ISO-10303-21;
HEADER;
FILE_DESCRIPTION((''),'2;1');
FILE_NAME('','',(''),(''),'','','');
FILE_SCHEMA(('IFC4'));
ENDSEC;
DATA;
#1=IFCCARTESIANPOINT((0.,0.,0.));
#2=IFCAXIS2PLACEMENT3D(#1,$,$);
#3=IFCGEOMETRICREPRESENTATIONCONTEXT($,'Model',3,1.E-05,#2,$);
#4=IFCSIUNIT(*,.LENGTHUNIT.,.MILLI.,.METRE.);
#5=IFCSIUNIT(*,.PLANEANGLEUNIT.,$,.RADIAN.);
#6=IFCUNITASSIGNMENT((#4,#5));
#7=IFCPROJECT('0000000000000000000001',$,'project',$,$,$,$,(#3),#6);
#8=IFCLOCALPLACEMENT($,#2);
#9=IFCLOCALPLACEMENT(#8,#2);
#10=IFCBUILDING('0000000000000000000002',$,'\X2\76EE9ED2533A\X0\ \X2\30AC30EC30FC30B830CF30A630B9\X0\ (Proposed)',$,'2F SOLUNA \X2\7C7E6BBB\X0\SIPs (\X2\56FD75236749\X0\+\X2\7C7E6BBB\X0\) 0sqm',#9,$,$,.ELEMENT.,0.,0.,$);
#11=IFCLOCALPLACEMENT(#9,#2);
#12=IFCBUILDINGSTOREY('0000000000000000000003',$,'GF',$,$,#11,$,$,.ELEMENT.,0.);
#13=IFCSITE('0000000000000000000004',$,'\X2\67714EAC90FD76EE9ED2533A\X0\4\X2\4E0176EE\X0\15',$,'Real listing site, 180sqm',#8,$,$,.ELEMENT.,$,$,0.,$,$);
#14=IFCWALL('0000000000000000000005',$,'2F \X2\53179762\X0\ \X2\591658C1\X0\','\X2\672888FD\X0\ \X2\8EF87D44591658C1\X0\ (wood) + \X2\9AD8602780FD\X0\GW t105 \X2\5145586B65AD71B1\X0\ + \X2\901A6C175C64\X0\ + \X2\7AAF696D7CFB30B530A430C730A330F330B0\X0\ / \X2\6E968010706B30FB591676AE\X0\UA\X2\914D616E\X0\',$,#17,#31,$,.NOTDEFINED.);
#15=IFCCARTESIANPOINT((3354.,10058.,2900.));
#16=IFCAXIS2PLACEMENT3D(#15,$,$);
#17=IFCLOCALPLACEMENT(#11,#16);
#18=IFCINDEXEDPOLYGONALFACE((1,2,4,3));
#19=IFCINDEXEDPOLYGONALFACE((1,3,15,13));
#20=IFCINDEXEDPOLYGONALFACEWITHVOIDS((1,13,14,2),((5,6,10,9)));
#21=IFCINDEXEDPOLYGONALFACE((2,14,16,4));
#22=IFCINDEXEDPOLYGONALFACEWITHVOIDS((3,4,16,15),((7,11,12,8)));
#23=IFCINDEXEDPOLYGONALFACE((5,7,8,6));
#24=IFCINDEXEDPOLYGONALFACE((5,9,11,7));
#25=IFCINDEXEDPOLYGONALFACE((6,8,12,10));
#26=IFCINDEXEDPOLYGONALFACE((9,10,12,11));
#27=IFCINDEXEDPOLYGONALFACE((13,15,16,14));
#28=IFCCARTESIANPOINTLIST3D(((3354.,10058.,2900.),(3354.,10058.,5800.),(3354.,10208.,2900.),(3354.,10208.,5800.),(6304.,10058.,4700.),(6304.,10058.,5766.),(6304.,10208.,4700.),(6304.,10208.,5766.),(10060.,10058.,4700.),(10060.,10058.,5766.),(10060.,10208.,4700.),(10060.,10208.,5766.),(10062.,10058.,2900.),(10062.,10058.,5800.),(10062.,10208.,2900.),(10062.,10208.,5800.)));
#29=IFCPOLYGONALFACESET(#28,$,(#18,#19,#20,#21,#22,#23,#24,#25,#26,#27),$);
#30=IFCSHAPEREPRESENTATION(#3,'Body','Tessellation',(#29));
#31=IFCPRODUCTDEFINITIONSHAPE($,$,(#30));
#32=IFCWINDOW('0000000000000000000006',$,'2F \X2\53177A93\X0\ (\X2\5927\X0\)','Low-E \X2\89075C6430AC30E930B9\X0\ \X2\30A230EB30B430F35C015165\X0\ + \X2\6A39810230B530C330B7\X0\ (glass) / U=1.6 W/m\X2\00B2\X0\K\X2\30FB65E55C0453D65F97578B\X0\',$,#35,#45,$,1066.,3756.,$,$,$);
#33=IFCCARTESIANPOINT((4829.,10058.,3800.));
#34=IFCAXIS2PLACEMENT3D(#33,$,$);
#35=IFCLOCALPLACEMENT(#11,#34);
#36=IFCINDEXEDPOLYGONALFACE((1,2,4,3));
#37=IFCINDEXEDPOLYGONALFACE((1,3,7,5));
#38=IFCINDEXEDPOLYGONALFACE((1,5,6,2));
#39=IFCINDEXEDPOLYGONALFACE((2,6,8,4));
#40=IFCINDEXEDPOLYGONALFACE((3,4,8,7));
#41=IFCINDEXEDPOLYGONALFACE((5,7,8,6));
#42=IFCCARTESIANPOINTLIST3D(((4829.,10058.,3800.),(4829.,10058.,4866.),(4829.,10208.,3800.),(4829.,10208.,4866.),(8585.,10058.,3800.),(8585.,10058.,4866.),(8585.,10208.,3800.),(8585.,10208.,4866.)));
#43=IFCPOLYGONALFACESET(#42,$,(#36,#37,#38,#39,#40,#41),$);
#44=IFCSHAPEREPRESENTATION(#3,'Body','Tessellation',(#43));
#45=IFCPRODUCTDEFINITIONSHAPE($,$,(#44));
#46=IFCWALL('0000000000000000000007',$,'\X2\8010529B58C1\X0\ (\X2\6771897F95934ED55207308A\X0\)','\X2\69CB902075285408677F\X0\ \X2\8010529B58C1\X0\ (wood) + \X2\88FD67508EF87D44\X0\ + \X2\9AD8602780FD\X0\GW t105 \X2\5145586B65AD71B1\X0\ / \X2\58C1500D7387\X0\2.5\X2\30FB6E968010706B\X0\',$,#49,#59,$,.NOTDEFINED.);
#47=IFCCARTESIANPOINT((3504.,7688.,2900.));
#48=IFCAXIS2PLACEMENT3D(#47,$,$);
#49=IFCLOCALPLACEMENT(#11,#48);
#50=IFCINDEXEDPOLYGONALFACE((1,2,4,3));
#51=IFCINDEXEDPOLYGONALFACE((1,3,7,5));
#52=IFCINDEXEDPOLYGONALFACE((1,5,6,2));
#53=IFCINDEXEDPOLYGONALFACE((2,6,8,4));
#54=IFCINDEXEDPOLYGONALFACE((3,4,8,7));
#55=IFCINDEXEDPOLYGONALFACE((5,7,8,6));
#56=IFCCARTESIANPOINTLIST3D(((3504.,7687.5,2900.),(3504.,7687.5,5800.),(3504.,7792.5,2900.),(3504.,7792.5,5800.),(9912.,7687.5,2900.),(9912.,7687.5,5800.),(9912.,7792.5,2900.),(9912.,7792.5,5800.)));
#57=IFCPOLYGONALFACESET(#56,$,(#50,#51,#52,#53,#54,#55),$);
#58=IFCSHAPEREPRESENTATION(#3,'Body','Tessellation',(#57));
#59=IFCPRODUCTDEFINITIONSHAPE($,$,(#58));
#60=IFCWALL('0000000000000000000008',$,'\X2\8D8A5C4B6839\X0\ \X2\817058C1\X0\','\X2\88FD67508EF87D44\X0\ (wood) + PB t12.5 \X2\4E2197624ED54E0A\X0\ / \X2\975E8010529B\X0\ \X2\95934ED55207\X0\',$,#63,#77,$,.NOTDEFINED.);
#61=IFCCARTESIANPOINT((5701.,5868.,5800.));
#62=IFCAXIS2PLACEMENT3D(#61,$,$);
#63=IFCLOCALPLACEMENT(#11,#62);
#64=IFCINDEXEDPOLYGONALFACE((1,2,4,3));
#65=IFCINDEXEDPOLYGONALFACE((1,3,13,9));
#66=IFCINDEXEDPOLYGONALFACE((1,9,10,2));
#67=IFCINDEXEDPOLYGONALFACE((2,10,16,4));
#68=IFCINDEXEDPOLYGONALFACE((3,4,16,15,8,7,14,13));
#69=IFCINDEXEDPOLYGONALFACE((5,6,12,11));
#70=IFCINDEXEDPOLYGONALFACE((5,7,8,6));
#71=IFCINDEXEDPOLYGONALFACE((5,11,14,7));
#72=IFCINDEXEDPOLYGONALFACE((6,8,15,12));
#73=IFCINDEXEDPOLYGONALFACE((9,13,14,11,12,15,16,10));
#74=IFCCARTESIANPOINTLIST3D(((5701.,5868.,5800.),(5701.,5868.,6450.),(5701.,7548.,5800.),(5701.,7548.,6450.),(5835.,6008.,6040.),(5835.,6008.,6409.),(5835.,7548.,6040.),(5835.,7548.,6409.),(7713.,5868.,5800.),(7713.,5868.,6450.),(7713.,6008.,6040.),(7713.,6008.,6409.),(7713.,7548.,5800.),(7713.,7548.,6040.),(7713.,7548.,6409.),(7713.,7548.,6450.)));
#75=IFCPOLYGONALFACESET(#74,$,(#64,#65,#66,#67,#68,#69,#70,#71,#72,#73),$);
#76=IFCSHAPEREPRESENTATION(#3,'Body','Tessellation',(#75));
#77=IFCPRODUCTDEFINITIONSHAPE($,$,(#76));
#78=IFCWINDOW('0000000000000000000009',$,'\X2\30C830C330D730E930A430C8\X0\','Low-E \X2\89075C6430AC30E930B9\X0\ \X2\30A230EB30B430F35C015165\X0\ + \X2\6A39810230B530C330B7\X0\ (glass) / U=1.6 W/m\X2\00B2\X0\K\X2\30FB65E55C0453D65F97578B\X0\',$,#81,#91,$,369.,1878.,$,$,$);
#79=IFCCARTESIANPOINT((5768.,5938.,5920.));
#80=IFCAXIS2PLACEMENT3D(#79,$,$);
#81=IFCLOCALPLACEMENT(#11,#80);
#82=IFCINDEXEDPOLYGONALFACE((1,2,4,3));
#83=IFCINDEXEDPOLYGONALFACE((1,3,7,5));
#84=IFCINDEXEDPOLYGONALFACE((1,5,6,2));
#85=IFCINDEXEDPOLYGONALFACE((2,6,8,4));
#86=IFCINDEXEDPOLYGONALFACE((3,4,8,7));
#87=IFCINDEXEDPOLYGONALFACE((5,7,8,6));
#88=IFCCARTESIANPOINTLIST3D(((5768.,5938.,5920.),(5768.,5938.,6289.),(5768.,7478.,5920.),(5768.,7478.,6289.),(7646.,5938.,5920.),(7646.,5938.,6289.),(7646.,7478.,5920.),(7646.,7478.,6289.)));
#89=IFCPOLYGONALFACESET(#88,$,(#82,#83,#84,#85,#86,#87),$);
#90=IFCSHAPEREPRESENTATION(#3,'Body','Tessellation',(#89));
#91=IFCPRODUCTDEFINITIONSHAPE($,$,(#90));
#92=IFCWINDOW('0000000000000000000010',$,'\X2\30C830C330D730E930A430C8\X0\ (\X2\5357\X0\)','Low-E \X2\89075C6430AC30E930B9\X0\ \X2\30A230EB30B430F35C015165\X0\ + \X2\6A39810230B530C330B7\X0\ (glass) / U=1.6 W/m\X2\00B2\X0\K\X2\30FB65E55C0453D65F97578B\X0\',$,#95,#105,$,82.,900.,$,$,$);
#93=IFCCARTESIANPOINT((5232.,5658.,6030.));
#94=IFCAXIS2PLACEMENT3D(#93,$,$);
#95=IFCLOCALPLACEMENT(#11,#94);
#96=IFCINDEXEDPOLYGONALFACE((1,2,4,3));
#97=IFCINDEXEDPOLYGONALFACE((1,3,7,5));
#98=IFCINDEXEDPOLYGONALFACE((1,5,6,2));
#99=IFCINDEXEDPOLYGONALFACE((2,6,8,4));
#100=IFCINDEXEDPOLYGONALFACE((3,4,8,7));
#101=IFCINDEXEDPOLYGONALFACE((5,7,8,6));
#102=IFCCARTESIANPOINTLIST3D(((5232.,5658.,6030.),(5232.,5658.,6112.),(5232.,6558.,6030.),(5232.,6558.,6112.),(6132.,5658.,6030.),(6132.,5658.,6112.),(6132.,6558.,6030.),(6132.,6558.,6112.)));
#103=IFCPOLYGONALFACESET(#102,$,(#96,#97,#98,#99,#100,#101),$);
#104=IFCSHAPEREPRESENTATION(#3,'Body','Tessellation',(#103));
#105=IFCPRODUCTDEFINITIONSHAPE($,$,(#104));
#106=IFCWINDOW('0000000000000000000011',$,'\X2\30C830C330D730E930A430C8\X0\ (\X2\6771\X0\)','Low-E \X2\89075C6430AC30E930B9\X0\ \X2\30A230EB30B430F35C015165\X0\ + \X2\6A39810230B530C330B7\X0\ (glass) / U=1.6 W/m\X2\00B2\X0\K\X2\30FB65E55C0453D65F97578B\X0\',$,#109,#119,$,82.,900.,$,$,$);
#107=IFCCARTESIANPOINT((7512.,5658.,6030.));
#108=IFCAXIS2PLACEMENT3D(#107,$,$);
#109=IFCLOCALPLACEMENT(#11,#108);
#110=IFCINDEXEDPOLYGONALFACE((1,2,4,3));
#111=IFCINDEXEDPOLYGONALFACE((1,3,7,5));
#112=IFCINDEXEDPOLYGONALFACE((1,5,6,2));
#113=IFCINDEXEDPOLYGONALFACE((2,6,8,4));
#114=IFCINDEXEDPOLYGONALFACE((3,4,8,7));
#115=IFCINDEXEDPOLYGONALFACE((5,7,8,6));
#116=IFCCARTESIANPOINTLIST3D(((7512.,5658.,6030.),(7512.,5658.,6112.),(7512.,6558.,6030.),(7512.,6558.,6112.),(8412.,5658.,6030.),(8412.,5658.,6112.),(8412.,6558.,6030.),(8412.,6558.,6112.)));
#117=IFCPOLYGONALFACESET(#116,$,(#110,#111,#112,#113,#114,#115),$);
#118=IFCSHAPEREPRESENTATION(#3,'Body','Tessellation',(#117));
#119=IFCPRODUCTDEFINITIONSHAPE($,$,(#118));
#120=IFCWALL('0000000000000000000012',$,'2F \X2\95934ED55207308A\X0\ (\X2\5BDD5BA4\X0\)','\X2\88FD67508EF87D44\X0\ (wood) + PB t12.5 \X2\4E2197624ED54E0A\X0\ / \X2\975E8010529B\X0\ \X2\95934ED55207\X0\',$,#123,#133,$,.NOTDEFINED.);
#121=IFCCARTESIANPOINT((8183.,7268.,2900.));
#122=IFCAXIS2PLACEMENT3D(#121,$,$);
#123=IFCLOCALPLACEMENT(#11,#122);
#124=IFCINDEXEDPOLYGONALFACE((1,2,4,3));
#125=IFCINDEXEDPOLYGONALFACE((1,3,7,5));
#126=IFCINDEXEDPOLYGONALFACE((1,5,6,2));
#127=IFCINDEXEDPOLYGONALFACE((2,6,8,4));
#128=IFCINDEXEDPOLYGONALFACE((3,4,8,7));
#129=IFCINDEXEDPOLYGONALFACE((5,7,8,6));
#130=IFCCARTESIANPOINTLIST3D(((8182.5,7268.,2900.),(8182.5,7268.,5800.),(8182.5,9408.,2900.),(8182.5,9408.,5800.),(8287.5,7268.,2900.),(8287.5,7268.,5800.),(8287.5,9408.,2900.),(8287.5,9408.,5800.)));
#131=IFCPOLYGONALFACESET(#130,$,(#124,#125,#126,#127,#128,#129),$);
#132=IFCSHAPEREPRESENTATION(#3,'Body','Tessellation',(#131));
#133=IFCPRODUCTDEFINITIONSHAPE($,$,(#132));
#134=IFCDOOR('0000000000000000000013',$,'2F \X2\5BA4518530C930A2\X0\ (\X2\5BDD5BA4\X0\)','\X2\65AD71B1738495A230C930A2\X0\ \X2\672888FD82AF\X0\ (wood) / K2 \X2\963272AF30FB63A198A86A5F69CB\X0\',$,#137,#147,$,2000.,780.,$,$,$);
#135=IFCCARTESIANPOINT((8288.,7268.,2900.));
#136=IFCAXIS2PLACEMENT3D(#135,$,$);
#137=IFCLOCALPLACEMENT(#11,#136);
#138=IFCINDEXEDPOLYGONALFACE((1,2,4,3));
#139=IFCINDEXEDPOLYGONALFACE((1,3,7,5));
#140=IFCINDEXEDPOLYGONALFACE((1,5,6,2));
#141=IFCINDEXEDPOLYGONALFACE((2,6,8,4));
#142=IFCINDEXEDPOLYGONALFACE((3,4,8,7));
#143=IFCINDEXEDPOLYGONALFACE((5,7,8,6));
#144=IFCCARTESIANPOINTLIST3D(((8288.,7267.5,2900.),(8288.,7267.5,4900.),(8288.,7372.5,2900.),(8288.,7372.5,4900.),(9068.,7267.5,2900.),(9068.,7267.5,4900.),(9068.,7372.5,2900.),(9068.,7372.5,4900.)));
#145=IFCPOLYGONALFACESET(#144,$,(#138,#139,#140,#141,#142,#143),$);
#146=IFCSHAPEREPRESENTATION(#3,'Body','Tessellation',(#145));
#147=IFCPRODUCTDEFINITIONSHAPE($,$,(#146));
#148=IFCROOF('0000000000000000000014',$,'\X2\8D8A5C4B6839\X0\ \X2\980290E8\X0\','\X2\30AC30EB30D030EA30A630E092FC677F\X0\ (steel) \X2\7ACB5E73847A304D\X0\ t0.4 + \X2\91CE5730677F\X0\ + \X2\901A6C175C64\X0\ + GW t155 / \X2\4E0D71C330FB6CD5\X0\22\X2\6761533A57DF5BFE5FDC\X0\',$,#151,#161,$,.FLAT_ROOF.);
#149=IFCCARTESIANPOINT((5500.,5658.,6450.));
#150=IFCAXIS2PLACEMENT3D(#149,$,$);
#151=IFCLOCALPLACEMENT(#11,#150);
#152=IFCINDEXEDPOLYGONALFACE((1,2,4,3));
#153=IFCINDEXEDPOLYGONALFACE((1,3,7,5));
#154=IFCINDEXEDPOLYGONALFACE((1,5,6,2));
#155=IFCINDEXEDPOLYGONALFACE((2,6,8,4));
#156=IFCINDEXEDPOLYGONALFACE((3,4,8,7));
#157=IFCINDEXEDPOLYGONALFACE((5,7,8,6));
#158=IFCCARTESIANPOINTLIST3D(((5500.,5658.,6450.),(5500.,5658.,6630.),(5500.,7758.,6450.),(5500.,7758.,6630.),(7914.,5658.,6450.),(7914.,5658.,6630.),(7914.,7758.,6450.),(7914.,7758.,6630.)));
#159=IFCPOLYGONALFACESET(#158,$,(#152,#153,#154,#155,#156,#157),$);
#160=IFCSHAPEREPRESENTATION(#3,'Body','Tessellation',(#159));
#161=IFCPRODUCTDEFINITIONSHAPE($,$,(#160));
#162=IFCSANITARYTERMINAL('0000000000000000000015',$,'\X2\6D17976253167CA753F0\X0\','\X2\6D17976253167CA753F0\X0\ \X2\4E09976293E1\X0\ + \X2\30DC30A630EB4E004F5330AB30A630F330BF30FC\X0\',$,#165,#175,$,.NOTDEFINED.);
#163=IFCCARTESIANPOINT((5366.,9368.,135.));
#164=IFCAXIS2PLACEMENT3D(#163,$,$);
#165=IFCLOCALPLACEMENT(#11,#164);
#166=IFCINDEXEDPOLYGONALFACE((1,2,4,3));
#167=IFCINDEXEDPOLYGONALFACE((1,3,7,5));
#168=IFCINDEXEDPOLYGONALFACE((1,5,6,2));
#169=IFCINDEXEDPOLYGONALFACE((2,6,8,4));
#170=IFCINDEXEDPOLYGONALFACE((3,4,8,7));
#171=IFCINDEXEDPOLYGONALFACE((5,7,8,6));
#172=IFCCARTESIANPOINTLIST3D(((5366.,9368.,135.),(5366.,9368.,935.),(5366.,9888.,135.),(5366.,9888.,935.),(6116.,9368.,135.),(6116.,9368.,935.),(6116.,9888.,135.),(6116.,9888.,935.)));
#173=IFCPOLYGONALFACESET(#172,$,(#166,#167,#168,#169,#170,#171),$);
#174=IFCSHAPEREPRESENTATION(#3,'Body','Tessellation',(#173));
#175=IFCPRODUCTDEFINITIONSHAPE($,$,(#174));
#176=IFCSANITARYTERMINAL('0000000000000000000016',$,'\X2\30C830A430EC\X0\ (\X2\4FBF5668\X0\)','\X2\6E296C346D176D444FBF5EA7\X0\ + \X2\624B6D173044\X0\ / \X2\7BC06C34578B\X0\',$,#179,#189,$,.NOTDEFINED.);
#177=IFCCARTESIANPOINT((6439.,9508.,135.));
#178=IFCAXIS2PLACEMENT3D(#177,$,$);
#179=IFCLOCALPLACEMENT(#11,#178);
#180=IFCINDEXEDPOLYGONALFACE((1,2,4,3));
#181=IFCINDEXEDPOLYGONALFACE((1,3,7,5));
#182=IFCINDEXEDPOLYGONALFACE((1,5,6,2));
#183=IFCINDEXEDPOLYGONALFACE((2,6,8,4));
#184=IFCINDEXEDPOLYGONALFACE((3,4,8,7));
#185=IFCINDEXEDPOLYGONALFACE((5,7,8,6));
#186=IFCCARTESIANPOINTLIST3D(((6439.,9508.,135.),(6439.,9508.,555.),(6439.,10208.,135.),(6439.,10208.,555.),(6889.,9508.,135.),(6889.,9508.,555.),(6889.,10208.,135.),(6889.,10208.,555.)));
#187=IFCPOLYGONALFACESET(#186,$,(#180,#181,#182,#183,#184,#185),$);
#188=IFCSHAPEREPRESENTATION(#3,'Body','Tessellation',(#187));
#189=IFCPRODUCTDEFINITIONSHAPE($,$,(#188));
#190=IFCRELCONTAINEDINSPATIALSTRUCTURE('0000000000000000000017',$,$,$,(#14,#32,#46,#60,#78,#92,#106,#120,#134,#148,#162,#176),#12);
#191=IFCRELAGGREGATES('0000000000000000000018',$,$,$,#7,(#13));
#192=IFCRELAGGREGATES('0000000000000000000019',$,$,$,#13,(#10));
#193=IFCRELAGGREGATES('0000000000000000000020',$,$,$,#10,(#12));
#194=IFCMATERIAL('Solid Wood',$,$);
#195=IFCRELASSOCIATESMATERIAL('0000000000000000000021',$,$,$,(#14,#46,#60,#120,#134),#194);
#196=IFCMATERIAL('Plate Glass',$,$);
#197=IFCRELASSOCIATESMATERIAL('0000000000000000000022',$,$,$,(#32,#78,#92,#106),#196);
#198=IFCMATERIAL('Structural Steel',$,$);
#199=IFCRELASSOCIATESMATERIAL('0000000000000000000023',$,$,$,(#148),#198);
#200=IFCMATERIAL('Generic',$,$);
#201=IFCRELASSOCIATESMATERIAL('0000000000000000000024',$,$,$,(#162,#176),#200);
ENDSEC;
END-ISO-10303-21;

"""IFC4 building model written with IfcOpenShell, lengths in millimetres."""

from ifc_helpers import new_model, si_unit, frame, frame_2d, origin, place, context, project, spatial, rectangle, extrude, material, element, fill, save


model = new_model("IFC4")

# Units and contexts
model_context = context("Model", 3, precision=1e-05, world=origin())
ifc_project = project(units=[si_unit("LENGTHUNIT", "METRE", prefix="MILLI"), si_unit("PLANEANGLEUNIT", "RADIAN")], contexts=[model_context])

# Site, building, storey
site_placement = place(None, origin())
site = spatial("IfcSite", under=ifc_project, at=site_placement, Name="東京都目黒区4丁目15", ObjectType="Real listing site, 180sqm", CompositionType="ELEMENT", RefElevation=0.0)
building_placement = place(site_placement, origin())
building = spatial("IfcBuilding", under=site, at=building_placement, Name="目黒区 ガレージハウス (Proposed)", ObjectType="2F SOLUNA 籾殻SIPs (国産杉+籾殻) 0sqm", CompositionType="ELEMENT", ElevationOfRefHeight=0.0, ElevationOfTerrain=0.0)
storey_placement = place(building_placement, origin())
storey = spatial("IfcBuildingStorey", under=building, at=storey_placement, Name="GF", CompositionType="ELEMENT", Elevation=0.0)

# Wall, opening, window
ifc_material_1 = material(Name="Solid Wood")
wall_1_placement = place(storey_placement, frame((3354.0, 10058.0, 2900.0)))
wall_1 = element("IfcWall", 1, at=wall_1_placement, inside=storey, material=ifc_material_1, Name="2F 北面 外壁", Description="木製 軸組外壁 (wood) + 高性能GW t105 充填断熱 + 通気層 + 窯業系サイディング / 準耐火・外皮UA配慮", PredefinedType="NOTDEFINED", context=model_context, shape_type="SweptSolid", body=[
    extrude(rectangle(XDim=6708.0, YDim=150.0, at=frame_2d((3354.0, 75.0))), frame((3354.0, 10058.0, 2900.0)), (0.0, 0.0, 1.0), 2900.0),
])
opening_1_placement = place(storey_placement, frame((4829.0, 10058.0, 3800.0)))
opening_1 = element("IfcOpeningElement", 2, at=opening_1_placement, cuts=wall_1, PredefinedType="NOTDEFINED", context=model_context, shape_type="SweptSolid", body=[
    extrude(rectangle(XDim=3756.0, YDim=150.0, at=frame_2d((1878.0, 75.0))), frame((4829.0, 10058.0, 3800.0)), (0.0, 0.0, 1.0), 1066.0),
])
ifc_material_2 = material(Name="Plate Glass")
window_1_placement = place(storey_placement, frame((4829.0, 10058.0, 3800.0)))
window_1 = element("IfcWindow", 3, at=window_1_placement, inside=storey, material=ifc_material_2, Name="2F 北窓 (大)", Description="Low-E 複層ガラス アルゴン封入 + 樹脂サッシ (glass) / U=1.6 W/m²K・日射取得型", OverallHeight=1066.0, OverallWidth=3756.0, context=model_context, shape_type="SweptSolid", body=[
    extrude(rectangle(XDim=3756.0, YDim=150.0, at=frame_2d((1878.0, 75.0))), frame((4829.0, 10058.0, 3800.0)), (0.0, 0.0, 1.0), 1066.0),
])
fill(opening_1, window_1)

# Wall
wall_2_placement = place(storey_placement, frame((3504.0, 7688.0, 2900.0)))
element("IfcWall", 4, at=wall_2_placement, inside=storey, material=ifc_material_1, Name="耐力壁 (東西間仕切り)", Description="構造用合板 耐力壁 (wood) + 製材軸組 + 高性能GW t105 充填断熱 / 壁倍率2.5・準耐火", PredefinedType="NOTDEFINED", context=model_context, shape_type="SweptSolid", body=[
    extrude(rectangle(XDim=6408.0, YDim=105.0, at=frame_2d((3204.0, 52.0))), frame((3504.0, 7688.0, 2900.0)), (0.0, 0.0, 1.0), 2900.0),
])

# Wall, openings, windows
wall_3_placement = place(storey_placement, frame((5701.0, 5868.0, 5800.0)))
wall_3 = element("IfcWall", 5, at=wall_3_placement, inside=storey, material=ifc_material_1, Name="越屋根 腰壁", Description="製材軸組 (wood) + PB t12.5 両面仕上 / 非耐力 間仕切", PredefinedType="NOTDEFINED", context=model_context, shape_type="SweptSolid", body=[
    extrude(rectangle(XDim=2012.0, YDim=1680.0, at=frame_2d((1006.0, 840.0))), frame((5701.0, 5868.0, 5800.0)), (0.0, 0.0, 1.0), 650.0),
])
opening_2_placement = place(storey_placement, frame((5768.0, 5938.0, 5920.0)))
opening_2 = element("IfcOpeningElement", 6, at=opening_2_placement, cuts=wall_3, PredefinedType="NOTDEFINED", context=model_context, shape_type="SweptSolid", body=[
    extrude(rectangle(XDim=1878.0, YDim=1540.0, at=frame_2d((939.0, 770.0))), frame((5768.0, 5938.0, 5920.0)), (0.0, 0.0, 1.0), 369.0),
])
opening_3_placement = place(storey_placement, frame((5232.0, 5658.0, 6030.0)))
opening_3 = element("IfcOpeningElement", 7, at=opening_3_placement, cuts=wall_3, PredefinedType="NOTDEFINED", context=model_context, shape_type="SweptSolid", body=[
    extrude(rectangle(XDim=900.0, YDim=900.0, at=frame_2d((450.0, 450.0))), frame((5232.0, 5658.0, 6030.0)), (0.0, 0.0, 1.0), 82.0),
])
opening_4_placement = place(storey_placement, frame((7512.0, 5658.0, 6030.0)))
opening_4 = element("IfcOpeningElement", 8, at=opening_4_placement, cuts=wall_3, PredefinedType="NOTDEFINED", context=model_context, shape_type="SweptSolid", body=[
    extrude(rectangle(XDim=900.0, YDim=900.0, at=frame_2d((450.0, 450.0))), frame((7512.0, 5658.0, 6030.0)), (0.0, 0.0, 1.0), 82.0),
])
window_2_placement = place(storey_placement, frame((5768.0, 5938.0, 5920.0)))
window_2 = element("IfcWindow", 9, at=window_2_placement, inside=storey, material=ifc_material_2, Name="トップライト", Description="Low-E 複層ガラス アルゴン封入 + 樹脂サッシ (glass) / U=1.6 W/m²K・日射取得型", OverallHeight=369.0, OverallWidth=1878.0, context=model_context, shape_type="SweptSolid", body=[
    extrude(rectangle(XDim=1878.0, YDim=1540.0, at=frame_2d((939.0, 770.0))), frame((5768.0, 5938.0, 5920.0)), (0.0, 0.0, 1.0), 369.0),
])
fill(opening_2, window_2)
window_3_placement = place(storey_placement, frame((5232.0, 5658.0, 6030.0)))
window_3 = element("IfcWindow", 10, at=window_3_placement, inside=storey, material=ifc_material_2, Name="トップライト (南)", Description="Low-E 複層ガラス アルゴン封入 + 樹脂サッシ (glass) / U=1.6 W/m²K・日射取得型", OverallHeight=82.0, OverallWidth=900.0, context=model_context, shape_type="SweptSolid", body=[
    extrude(rectangle(XDim=900.0, YDim=900.0, at=frame_2d((450.0, 450.0))), frame((5232.0, 5658.0, 6030.0)), (0.0, 0.0, 1.0), 82.0),
])
fill(opening_3, window_3)
window_4_placement = place(storey_placement, frame((7512.0, 5658.0, 6030.0)))
window_4 = element("IfcWindow", 11, at=window_4_placement, inside=storey, material=ifc_material_2, Name="トップライト (東)", Description="Low-E 複層ガラス アルゴン封入 + 樹脂サッシ (glass) / U=1.6 W/m²K・日射取得型", OverallHeight=82.0, OverallWidth=900.0, context=model_context, shape_type="SweptSolid", body=[
    extrude(rectangle(XDim=900.0, YDim=900.0, at=frame_2d((450.0, 450.0))), frame((7512.0, 5658.0, 6030.0)), (0.0, 0.0, 1.0), 82.0),
])
fill(opening_4, window_4)

# Wall
wall_4_placement = place(storey_placement, frame((8183.0, 7268.0, 2900.0)))
element("IfcWall", 12, at=wall_4_placement, inside=storey, material=ifc_material_1, Name="2F 間仕切り (寝室)", Description="製材軸組 (wood) + PB t12.5 両面仕上 / 非耐力 間仕切", PredefinedType="NOTDEFINED", context=model_context, shape_type="SweptSolid", body=[
    extrude(rectangle(XDim=105.0, YDim=2140.0, at=frame_2d((52.0, 1070.0))), frame((8183.0, 7268.0, 2900.0)), (0.0, 0.0, 1.0), 2900.0),
])

# Door
door_placement = place(storey_placement, frame((8288.0, 7268.0, 2900.0)))
element("IfcDoor", 13, at=door_placement, inside=storey, material=ifc_material_1, Name="2F 室内ドア (寝室)", Description="断熱玄関ドア 木製芯 (wood) / K2 防犯・採風機構", OverallHeight=2000.0, OverallWidth=780.0, context=model_context, shape_type="SweptSolid", body=[
    extrude(rectangle(XDim=780.0, YDim=105.0, at=frame_2d((390.0, 52.0))), frame((8288.0, 7268.0, 2900.0)), (0.0, 0.0, 1.0), 2000.0),
])

# Roof
ifc_material_3 = material(Name="Structural Steel")
roof_placement = place(storey_placement, frame((5500.0, 5658.0, 6450.0)))
element("IfcRoof", 14, at=roof_placement, inside=storey, material=ifc_material_3, Name="越屋根 頂部", Description="ガルバリウム鋼板 (steel) 立平葺き t0.4 + 野地板 + 通気層 + GW t155 / 不燃・法22条区域対応", PredefinedType="FLAT_ROOF", context=model_context, shape_type="SweptSolid", body=[
    extrude(rectangle(XDim=2414.0, YDim=2100.0, at=frame_2d((1207.0, 1050.0))), frame((5500.0, 5658.0, 6450.0)), (0.0, 0.0, 1.0), 180.0),
])

# Sanitary terminals
ifc_material_4 = material(Name="Generic")
sanitary_terminal_1_placement = place(storey_placement, frame((5366.0, 9368.0, 135.0)))
element("IfcSanitaryTerminal", 15, at=sanitary_terminal_1_placement, inside=storey, material=ifc_material_4, Name="洗面化粧台", Description="洗面化粧台 三面鏡 + ボウル一体カウンター", PredefinedType="NOTDEFINED", context=model_context, shape_type="SweptSolid", body=[
    extrude(rectangle(XDim=750.0, YDim=520.0, at=frame_2d((375.0, 260.0))), frame((5366.0, 9368.0, 135.0)), (0.0, 0.0, 1.0), 800.0),
])
sanitary_terminal_2_placement = place(storey_placement, frame((6439.0, 9508.0, 135.0)))
element("IfcSanitaryTerminal", 16, at=sanitary_terminal_2_placement, inside=storey, material=ifc_material_4, Name="トイレ (便器)", Description="温水洗浄便座 + 手洗い / 節水型", PredefinedType="NOTDEFINED", context=model_context, shape_type="SweptSolid", body=[
    extrude(rectangle(XDim=450.0, YDim=700.0, at=frame_2d((225.0, 350.0))), frame((6439.0, 9508.0, 135.0)), (0.0, 0.0, 1.0), 420.0),
])

save(model, "model.ifc")
